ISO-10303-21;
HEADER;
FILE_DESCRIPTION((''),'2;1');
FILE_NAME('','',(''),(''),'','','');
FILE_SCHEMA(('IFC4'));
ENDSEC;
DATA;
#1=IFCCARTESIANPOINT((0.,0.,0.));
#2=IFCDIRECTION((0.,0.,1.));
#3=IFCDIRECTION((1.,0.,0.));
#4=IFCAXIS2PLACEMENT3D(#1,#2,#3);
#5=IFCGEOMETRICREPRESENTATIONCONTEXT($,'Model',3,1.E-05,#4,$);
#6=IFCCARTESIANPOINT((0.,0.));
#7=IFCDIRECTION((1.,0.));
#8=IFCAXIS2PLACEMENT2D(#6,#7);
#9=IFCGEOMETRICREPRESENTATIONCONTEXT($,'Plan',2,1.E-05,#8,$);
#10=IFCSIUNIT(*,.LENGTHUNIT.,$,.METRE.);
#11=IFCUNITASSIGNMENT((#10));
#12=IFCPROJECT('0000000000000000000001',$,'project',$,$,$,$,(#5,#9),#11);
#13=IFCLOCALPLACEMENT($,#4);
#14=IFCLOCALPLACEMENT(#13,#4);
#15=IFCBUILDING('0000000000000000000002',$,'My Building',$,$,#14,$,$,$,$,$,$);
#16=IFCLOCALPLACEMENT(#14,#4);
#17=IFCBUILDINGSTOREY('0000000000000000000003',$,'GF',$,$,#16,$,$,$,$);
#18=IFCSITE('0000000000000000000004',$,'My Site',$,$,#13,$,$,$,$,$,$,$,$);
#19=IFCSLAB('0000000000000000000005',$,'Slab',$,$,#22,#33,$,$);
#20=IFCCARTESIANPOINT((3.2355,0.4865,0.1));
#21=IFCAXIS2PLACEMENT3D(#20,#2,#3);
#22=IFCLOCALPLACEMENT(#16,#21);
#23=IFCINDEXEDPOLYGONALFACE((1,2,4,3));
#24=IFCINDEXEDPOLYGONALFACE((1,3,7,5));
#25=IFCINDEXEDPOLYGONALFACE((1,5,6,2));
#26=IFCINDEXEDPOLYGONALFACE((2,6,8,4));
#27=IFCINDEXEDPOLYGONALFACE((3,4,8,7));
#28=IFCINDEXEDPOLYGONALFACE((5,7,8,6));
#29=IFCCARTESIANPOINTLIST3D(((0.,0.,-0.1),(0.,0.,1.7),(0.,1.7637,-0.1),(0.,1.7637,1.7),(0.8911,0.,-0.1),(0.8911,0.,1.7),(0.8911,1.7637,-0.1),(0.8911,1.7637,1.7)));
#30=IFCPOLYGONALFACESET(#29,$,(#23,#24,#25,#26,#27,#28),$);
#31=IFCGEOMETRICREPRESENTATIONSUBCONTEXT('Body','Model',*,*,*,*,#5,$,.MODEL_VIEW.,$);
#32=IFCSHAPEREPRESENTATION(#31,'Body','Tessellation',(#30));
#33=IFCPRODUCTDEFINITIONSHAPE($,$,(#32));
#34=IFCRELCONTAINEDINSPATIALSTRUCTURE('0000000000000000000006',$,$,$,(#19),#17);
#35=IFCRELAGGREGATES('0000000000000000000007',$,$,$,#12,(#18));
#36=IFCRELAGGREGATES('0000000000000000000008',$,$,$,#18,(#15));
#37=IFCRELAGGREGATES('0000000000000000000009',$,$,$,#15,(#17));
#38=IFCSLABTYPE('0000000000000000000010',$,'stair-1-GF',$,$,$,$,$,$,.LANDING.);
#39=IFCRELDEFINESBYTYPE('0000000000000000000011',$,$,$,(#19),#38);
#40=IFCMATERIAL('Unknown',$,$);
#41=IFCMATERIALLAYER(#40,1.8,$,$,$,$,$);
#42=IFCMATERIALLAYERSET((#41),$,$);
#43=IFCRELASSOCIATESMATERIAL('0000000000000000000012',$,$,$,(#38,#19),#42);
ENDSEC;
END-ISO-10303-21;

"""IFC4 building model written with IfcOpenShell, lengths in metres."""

from ifc_helpers import new_model, si_unit, frame, origin_with_axes, origin_2d_with_axis, place, context, subcontext, project, spatial, indexed_curve, outline, extrude, material, layer, layer_set, layer_usage, type_object, element, save


model = new_model("IFC4")

# Units and contexts
model_context = context("Model", 3, precision=1e-05, world=origin_with_axes())
plan_context = context("Plan", 2, precision=1e-05, world=origin_2d_with_axis())
body_context_1 = subcontext(model_context, "Body", "Model", "MODEL_VIEW")
ifc_project = project(units=[si_unit("LENGTHUNIT", "METRE")], contexts=[model_context, plan_context])

# Site, building, storey
site_placement = place(None, origin_with_axes())
site = spatial("IfcSite", under=ifc_project, at=site_placement, Name="My Site")
building_placement = place(site_placement, origin_with_axes())
building = spatial("IfcBuilding", under=site, at=building_placement, Name="My Building")
storey_placement = place(building_placement, origin_with_axes())
storey = spatial("IfcBuildingStorey", under=building, at=storey_placement, Name="GF")

# Shared definitions
ifc_material = material(Name="Unknown")

# Slab
ifc_layer_1 = layer(ifc_material, 1.8)
ifc_layer_set_1 = layer_set([ifc_layer_1])
slab_type_1 = type_object("IfcSlabType", Name="stair-1-GF", PredefinedType="LANDING", material=ifc_layer_set_1)
ifc_layer_usage_1 = layer_usage(ifc_layer_set_1, "AXIS3", "POSITIVE", -0.1)
slab_1_placement = place(storey_placement, frame((3.2355, 0.4865, 0.1), z_axis=(0.0, 0.0, 1.0), x_axis=(1.0, 0.0, 0.0)))
element("IfcSlab", 1, at=slab_1_placement, inside=storey, type_object=slab_type_1, material=ifc_layer_usage_1, Name="Slab", context=body_context_1, shape_type="SweptSolid", body=[
    extrude(outline(indexed_curve([(0.0, 0.0), (0.0, 1.7637), (0.8911, 1.7637), (0.8911, 0.0), (0.0, 0.0)])), frame((0.0, 0.0, -0.1), z_axis=(0.0, 0.0, 1.0), x_axis=(1.0, 0.0, 0.0)), (0.0, 0.0, 1.0), 1.8),
])

save(model, "model.ifc")
